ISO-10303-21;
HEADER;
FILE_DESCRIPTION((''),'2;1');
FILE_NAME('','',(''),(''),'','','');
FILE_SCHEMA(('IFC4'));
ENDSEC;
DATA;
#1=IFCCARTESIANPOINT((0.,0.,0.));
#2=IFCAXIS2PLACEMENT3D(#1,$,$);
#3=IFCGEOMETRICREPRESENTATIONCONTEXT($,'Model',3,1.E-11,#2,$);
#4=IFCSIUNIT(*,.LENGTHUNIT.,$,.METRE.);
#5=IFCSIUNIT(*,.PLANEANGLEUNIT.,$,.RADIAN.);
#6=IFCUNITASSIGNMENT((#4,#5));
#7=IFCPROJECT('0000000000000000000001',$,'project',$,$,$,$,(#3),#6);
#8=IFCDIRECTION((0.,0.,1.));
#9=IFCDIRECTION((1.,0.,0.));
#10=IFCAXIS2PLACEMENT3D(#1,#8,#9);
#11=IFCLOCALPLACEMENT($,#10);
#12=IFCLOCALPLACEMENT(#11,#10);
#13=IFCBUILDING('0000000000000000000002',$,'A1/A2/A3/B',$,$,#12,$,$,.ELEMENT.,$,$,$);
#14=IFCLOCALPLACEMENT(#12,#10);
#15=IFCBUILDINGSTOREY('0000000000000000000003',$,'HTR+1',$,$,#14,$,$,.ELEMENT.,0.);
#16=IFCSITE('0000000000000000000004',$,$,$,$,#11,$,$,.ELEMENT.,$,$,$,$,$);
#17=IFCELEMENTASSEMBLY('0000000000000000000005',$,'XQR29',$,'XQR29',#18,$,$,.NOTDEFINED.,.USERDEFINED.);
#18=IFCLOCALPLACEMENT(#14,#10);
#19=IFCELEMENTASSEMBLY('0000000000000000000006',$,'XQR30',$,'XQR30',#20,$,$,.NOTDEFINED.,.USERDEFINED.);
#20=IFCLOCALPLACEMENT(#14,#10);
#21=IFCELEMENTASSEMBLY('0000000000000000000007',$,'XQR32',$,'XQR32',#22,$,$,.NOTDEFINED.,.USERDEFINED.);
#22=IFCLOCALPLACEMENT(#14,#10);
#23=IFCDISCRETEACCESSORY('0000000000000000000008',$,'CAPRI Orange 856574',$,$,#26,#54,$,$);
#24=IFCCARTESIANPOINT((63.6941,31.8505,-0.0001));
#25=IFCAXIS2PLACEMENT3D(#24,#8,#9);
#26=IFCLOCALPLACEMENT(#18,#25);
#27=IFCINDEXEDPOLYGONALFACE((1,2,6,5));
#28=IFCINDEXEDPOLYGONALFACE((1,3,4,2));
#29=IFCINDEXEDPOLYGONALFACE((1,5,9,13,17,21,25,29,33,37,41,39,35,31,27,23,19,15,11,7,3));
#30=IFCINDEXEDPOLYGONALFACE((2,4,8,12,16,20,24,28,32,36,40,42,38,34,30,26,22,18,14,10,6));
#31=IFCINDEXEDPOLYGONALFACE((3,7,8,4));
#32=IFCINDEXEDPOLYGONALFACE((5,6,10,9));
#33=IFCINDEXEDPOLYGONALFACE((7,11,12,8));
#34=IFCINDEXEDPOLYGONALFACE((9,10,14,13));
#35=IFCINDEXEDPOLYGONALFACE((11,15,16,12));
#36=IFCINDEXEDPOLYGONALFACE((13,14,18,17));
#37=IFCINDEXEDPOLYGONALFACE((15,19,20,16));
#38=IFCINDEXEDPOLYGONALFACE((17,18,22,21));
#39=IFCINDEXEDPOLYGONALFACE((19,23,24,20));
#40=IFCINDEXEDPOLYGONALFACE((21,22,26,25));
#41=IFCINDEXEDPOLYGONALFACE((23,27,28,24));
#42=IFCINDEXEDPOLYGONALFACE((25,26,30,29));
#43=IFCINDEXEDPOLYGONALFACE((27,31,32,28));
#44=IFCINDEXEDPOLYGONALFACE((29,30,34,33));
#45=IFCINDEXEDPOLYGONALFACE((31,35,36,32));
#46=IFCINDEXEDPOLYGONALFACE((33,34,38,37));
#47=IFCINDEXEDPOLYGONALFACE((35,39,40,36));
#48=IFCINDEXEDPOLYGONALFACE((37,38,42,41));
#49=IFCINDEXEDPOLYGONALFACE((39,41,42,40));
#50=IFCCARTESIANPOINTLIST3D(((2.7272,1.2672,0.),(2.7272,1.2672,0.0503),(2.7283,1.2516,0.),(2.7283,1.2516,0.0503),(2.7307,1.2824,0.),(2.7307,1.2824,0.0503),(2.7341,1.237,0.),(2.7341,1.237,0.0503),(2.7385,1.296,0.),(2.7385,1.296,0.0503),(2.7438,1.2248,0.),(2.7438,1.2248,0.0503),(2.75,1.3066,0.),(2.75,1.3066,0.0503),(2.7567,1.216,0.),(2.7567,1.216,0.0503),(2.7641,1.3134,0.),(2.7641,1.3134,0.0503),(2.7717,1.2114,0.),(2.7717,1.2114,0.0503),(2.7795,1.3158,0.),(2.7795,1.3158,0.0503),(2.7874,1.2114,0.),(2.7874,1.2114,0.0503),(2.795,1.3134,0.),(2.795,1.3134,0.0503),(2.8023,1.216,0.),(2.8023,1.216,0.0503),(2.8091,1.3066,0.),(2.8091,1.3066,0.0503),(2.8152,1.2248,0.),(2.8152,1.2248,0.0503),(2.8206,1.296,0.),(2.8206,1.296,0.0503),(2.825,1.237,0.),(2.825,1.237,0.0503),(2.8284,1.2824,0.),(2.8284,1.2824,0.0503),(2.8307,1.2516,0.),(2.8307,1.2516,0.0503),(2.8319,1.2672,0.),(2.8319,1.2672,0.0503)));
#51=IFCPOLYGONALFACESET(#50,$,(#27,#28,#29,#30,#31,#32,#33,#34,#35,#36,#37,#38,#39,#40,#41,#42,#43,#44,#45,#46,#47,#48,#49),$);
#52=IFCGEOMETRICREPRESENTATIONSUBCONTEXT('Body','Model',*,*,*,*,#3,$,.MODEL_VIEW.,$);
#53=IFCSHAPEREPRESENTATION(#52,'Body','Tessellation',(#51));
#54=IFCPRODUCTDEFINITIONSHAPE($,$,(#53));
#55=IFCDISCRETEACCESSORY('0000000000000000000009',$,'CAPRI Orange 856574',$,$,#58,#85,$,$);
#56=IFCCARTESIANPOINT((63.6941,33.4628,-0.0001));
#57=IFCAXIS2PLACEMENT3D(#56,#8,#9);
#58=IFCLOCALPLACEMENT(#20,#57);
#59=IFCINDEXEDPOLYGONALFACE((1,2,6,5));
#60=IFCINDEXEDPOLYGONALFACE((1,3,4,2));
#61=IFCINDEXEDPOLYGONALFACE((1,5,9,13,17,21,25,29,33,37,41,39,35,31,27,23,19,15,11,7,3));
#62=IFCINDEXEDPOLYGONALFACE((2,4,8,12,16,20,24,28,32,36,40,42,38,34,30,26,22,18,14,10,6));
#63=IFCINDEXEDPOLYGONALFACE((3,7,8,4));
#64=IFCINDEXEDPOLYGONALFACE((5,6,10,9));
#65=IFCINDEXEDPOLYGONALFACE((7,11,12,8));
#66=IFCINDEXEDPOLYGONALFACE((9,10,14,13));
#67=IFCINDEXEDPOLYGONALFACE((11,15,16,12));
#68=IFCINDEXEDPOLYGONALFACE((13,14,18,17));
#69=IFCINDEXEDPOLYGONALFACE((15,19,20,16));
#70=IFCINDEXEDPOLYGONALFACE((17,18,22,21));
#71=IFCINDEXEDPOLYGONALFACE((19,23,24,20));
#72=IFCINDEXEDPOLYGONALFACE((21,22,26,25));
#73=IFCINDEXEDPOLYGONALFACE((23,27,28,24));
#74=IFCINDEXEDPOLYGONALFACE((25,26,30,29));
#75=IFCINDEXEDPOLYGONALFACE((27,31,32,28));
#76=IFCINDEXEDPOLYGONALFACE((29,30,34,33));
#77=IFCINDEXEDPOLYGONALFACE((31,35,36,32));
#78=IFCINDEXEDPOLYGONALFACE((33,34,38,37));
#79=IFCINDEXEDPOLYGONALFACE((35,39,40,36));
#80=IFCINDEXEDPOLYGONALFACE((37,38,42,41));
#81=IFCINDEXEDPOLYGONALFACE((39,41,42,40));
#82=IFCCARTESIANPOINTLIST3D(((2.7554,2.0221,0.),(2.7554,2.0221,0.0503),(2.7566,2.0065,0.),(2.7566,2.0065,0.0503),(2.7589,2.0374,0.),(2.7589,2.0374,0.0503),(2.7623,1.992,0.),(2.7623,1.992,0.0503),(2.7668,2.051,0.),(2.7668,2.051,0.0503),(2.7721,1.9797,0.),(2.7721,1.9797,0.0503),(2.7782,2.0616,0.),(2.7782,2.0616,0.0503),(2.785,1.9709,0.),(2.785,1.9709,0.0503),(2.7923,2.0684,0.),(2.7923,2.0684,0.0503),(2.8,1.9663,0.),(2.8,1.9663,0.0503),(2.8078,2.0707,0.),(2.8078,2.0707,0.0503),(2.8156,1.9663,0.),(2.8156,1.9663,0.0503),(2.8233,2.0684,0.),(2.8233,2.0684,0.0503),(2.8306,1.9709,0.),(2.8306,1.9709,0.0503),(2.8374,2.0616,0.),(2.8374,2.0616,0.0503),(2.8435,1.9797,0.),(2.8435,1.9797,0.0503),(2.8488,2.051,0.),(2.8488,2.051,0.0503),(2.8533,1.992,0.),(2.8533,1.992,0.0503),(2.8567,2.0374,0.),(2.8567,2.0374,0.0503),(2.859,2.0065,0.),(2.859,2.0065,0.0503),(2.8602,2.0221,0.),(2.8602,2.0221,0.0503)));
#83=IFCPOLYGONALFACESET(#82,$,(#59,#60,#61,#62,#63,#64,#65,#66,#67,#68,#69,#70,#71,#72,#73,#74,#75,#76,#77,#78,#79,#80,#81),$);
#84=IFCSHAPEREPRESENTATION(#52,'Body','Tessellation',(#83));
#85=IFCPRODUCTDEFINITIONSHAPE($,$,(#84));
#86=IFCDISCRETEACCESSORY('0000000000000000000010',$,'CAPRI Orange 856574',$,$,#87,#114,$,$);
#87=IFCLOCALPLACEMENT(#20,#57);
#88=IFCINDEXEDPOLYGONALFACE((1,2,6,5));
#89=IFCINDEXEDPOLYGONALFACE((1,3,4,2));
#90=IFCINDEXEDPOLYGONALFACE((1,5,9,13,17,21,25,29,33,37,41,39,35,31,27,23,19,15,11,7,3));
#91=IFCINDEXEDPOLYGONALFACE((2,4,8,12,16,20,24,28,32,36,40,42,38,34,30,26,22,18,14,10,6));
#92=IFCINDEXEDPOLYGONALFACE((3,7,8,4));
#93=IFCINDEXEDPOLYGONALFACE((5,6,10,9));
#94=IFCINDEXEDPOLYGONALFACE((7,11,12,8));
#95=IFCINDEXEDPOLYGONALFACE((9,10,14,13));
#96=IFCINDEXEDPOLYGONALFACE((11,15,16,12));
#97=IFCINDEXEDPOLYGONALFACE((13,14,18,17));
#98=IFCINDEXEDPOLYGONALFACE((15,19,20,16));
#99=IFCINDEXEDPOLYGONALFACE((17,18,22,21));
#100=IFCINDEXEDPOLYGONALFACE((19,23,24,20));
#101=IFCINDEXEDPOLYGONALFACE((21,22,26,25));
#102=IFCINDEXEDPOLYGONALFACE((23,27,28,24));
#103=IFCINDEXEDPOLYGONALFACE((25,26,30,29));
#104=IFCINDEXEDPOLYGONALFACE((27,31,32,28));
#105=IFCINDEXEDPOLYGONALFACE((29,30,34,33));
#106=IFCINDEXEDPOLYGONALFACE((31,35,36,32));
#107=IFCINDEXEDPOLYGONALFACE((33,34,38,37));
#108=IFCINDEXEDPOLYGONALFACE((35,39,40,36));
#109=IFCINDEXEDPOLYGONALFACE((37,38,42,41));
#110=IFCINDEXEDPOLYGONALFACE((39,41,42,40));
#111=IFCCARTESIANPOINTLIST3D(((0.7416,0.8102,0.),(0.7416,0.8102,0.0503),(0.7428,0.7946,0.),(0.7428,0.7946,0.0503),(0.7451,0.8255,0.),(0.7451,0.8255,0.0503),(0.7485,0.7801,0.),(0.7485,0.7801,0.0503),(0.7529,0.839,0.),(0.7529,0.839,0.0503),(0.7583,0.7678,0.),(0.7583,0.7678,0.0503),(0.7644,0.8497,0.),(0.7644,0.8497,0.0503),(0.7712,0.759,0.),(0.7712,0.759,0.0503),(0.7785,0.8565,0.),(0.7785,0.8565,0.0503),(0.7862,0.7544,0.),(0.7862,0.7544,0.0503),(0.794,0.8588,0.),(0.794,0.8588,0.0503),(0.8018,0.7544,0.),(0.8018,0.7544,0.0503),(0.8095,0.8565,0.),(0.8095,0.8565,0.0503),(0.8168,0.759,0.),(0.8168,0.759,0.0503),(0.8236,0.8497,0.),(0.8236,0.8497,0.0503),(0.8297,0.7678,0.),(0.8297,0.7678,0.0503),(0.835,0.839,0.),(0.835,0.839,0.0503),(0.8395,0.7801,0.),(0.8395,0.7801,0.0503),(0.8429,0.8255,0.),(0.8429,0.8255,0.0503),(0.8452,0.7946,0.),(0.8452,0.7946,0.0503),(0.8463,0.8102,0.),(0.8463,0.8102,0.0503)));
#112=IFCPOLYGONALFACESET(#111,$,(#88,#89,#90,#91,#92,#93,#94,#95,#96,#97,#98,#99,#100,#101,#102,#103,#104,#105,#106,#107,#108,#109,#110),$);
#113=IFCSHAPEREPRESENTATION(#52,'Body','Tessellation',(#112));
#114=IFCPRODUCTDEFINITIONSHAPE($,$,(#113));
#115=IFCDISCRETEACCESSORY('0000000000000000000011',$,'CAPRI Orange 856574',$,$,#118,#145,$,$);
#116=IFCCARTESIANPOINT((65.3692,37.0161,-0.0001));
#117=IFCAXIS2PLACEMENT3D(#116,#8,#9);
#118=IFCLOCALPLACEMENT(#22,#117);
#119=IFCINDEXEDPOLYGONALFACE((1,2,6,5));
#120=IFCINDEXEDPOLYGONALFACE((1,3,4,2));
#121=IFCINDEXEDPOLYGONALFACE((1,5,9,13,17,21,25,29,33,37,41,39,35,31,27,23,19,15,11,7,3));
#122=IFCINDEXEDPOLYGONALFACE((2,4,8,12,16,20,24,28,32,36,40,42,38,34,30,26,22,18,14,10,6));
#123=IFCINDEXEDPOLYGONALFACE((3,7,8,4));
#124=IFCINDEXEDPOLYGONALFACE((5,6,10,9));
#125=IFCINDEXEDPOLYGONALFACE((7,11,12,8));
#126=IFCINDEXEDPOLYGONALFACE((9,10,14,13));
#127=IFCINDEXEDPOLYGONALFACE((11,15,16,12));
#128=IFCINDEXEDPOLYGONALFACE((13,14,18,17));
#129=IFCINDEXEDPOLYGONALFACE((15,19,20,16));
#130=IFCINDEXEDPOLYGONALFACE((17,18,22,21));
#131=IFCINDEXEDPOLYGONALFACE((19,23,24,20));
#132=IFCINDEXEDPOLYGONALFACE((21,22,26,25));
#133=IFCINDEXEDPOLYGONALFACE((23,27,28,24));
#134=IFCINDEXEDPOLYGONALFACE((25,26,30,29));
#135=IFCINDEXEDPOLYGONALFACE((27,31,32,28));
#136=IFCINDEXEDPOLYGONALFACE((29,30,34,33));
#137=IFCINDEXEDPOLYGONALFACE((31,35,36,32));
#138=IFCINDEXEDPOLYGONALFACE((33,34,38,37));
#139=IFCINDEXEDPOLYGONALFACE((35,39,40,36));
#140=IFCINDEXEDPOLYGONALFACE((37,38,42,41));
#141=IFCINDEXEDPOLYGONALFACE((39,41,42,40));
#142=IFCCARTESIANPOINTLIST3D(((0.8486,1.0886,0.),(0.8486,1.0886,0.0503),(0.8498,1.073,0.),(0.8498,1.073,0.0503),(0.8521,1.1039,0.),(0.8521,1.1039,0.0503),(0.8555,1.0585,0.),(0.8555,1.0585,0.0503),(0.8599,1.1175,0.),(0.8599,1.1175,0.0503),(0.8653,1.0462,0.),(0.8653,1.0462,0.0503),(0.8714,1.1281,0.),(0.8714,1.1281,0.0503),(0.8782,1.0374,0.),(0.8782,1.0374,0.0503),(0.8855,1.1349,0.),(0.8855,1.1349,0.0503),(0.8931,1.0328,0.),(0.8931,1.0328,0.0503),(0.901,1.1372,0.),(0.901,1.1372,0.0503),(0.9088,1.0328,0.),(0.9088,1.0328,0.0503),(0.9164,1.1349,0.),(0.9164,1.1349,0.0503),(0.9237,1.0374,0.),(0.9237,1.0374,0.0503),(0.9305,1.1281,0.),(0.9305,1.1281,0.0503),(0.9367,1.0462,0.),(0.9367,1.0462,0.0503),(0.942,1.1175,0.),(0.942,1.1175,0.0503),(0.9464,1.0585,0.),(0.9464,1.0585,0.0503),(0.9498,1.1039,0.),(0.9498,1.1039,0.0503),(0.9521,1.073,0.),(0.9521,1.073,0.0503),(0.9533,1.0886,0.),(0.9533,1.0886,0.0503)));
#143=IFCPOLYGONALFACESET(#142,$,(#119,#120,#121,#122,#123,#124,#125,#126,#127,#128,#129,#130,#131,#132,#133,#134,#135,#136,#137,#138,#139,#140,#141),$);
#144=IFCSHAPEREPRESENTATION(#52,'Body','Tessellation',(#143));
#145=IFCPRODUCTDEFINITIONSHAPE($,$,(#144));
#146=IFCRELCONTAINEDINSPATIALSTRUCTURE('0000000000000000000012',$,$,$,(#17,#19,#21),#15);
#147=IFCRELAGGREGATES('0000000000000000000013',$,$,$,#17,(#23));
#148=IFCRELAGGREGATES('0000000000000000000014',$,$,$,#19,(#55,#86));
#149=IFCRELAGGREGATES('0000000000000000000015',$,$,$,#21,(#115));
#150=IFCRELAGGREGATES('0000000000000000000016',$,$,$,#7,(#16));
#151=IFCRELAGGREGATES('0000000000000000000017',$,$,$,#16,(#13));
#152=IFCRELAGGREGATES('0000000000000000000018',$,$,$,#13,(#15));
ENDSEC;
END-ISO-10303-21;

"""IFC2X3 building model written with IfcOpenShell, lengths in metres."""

from ifc_helpers import new_model, si_unit, frame, frame_2d, origin, origin_with_axes, place, context, subcontext, project, spatial, circle, extrude, element, aggregate, save


model = new_model("IFC2X3")

# Units and contexts
model_context = context("Model", 3, precision=1e-11, world=origin())
body_context = subcontext(model_context, "Body", "Model", "MODEL_VIEW")
ifc_project = project(units=[si_unit("LENGTHUNIT", "METRE"), si_unit("PLANEANGLEUNIT", "RADIAN")], contexts=[model_context])

# Site, building, storey
site_placement = place(None, origin_with_axes())
site = spatial("IfcSite", under=ifc_project, at=site_placement, CompositionType="ELEMENT")
building_placement = place(site_placement, origin_with_axes())
building = spatial("IfcBuilding", under=site, at=building_placement, Name="A1/A2/A3/B", CompositionType="ELEMENT")
storey_placement = place(building_placement, origin_with_axes())
storey = spatial("IfcBuildingStorey", under=building, at=storey_placement, Name="HTR+1", CompositionType="ELEMENT", Elevation=0.0)

# Element assembly
assembly_1_placement = place(storey_placement, origin_with_axes())
assembly_1 = element("IfcElementAssembly", 1, at=assembly_1_placement, inside=storey, Name="XQR29", ObjectType="XQR29", AssemblyPlace="NOTDEFINED", PredefinedType="USERDEFINED")

# Element assembly
assembly_2_placement = place(storey_placement, origin_with_axes())
assembly_2 = element("IfcElementAssembly", 2, at=assembly_2_placement, inside=storey, Name="XQR30", ObjectType="XQR30", AssemblyPlace="NOTDEFINED", PredefinedType="USERDEFINED")

# Element assembly
assembly_3_placement = place(storey_placement, origin_with_axes())
assembly_3 = element("IfcElementAssembly", 3, at=assembly_3_placement, inside=storey, Name="XQR32", ObjectType="XQR32", AssemblyPlace="NOTDEFINED", PredefinedType="USERDEFINED")

# Discrete accessory
discrete_accessory_1_placement = place(assembly_1_placement, frame((63.6941, 31.8505, -0.0001), z_axis=(0.0, 0.0, 1.0), x_axis=(1.0, 0.0, 0.0)))
discrete_accessory_1 = element("IfcDiscreteAccessory", 4, at=discrete_accessory_1_placement, Name="CAPRI Orange 856574", context=body_context, shape_type="SweptSolid", body=[
    extrude(circle(Radius=0.0525, at=frame_2d((1.2633, -2.7795), x_axis=(1.0, 0.0))), frame((0.0, 0.0, 0.0), z_axis=(0.0, 0.0, 1.0), x_axis=(0.0, 1.0, 0.0)), (0.0, 0.0, 1.0), 0.0503),
])

aggregate(assembly_1, [discrete_accessory_1])

# Discrete accessories
discrete_accessory_2_placement = place(assembly_2_placement, frame((63.6941, 33.4628, -0.0001), z_axis=(0.0, 0.0, 1.0), x_axis=(1.0, 0.0, 0.0)))
discrete_accessory_2 = element("IfcDiscreteAccessory", 5, at=discrete_accessory_2_placement, Name="CAPRI Orange 856574", context=body_context, shape_type="SweptSolid", body=[
    extrude(circle(Radius=0.0525, at=frame_2d((2.0182, -2.8078), x_axis=(1.0, 0.0))), frame((0.0, 0.0, 0.0), z_axis=(0.0, 0.0, 1.0), x_axis=(0.0, 1.0, 0.0)), (0.0, 0.0, 1.0), 0.0503),
])
discrete_accessory_3_placement = place(assembly_2_placement, frame((63.6941, 33.4628, -0.0001), z_axis=(0.0, 0.0, 1.0), x_axis=(1.0, 0.0, 0.0)))
discrete_accessory_3 = element("IfcDiscreteAccessory", 6, at=discrete_accessory_3_placement, Name="CAPRI Orange 856574", context=body_context, shape_type="SweptSolid", body=[
    extrude(circle(Radius=0.0525, at=frame_2d((0.8063, -0.794), x_axis=(1.0, 0.0))), frame((0.0, 0.0, 0.0), z_axis=(0.0, 0.0, 1.0), x_axis=(0.0, 1.0, 0.0)), (0.0, 0.0, 1.0), 0.0503),
])

aggregate(assembly_2, [discrete_accessory_2, discrete_accessory_3])

# Discrete accessory
discrete_accessory_4_placement = place(assembly_3_placement, frame((65.3692, 37.0161, -0.0001), z_axis=(0.0, 0.0, 1.0), x_axis=(1.0, 0.0, 0.0)))
discrete_accessory_4 = element("IfcDiscreteAccessory", 7, at=discrete_accessory_4_placement, Name="CAPRI Orange 856574", context=body_context, shape_type="SweptSolid", body=[
    extrude(circle(Radius=0.0525, at=frame_2d((1.0847, -0.901), x_axis=(1.0, 0.0))), frame((0.0, 0.0, 0.0), z_axis=(0.0, 0.0, 1.0), x_axis=(0.0, 1.0, 0.0)), (0.0, 0.0, 1.0), 0.0503),
])
aggregate(assembly_3, [discrete_accessory_4])

save(model, "model.ifc")
